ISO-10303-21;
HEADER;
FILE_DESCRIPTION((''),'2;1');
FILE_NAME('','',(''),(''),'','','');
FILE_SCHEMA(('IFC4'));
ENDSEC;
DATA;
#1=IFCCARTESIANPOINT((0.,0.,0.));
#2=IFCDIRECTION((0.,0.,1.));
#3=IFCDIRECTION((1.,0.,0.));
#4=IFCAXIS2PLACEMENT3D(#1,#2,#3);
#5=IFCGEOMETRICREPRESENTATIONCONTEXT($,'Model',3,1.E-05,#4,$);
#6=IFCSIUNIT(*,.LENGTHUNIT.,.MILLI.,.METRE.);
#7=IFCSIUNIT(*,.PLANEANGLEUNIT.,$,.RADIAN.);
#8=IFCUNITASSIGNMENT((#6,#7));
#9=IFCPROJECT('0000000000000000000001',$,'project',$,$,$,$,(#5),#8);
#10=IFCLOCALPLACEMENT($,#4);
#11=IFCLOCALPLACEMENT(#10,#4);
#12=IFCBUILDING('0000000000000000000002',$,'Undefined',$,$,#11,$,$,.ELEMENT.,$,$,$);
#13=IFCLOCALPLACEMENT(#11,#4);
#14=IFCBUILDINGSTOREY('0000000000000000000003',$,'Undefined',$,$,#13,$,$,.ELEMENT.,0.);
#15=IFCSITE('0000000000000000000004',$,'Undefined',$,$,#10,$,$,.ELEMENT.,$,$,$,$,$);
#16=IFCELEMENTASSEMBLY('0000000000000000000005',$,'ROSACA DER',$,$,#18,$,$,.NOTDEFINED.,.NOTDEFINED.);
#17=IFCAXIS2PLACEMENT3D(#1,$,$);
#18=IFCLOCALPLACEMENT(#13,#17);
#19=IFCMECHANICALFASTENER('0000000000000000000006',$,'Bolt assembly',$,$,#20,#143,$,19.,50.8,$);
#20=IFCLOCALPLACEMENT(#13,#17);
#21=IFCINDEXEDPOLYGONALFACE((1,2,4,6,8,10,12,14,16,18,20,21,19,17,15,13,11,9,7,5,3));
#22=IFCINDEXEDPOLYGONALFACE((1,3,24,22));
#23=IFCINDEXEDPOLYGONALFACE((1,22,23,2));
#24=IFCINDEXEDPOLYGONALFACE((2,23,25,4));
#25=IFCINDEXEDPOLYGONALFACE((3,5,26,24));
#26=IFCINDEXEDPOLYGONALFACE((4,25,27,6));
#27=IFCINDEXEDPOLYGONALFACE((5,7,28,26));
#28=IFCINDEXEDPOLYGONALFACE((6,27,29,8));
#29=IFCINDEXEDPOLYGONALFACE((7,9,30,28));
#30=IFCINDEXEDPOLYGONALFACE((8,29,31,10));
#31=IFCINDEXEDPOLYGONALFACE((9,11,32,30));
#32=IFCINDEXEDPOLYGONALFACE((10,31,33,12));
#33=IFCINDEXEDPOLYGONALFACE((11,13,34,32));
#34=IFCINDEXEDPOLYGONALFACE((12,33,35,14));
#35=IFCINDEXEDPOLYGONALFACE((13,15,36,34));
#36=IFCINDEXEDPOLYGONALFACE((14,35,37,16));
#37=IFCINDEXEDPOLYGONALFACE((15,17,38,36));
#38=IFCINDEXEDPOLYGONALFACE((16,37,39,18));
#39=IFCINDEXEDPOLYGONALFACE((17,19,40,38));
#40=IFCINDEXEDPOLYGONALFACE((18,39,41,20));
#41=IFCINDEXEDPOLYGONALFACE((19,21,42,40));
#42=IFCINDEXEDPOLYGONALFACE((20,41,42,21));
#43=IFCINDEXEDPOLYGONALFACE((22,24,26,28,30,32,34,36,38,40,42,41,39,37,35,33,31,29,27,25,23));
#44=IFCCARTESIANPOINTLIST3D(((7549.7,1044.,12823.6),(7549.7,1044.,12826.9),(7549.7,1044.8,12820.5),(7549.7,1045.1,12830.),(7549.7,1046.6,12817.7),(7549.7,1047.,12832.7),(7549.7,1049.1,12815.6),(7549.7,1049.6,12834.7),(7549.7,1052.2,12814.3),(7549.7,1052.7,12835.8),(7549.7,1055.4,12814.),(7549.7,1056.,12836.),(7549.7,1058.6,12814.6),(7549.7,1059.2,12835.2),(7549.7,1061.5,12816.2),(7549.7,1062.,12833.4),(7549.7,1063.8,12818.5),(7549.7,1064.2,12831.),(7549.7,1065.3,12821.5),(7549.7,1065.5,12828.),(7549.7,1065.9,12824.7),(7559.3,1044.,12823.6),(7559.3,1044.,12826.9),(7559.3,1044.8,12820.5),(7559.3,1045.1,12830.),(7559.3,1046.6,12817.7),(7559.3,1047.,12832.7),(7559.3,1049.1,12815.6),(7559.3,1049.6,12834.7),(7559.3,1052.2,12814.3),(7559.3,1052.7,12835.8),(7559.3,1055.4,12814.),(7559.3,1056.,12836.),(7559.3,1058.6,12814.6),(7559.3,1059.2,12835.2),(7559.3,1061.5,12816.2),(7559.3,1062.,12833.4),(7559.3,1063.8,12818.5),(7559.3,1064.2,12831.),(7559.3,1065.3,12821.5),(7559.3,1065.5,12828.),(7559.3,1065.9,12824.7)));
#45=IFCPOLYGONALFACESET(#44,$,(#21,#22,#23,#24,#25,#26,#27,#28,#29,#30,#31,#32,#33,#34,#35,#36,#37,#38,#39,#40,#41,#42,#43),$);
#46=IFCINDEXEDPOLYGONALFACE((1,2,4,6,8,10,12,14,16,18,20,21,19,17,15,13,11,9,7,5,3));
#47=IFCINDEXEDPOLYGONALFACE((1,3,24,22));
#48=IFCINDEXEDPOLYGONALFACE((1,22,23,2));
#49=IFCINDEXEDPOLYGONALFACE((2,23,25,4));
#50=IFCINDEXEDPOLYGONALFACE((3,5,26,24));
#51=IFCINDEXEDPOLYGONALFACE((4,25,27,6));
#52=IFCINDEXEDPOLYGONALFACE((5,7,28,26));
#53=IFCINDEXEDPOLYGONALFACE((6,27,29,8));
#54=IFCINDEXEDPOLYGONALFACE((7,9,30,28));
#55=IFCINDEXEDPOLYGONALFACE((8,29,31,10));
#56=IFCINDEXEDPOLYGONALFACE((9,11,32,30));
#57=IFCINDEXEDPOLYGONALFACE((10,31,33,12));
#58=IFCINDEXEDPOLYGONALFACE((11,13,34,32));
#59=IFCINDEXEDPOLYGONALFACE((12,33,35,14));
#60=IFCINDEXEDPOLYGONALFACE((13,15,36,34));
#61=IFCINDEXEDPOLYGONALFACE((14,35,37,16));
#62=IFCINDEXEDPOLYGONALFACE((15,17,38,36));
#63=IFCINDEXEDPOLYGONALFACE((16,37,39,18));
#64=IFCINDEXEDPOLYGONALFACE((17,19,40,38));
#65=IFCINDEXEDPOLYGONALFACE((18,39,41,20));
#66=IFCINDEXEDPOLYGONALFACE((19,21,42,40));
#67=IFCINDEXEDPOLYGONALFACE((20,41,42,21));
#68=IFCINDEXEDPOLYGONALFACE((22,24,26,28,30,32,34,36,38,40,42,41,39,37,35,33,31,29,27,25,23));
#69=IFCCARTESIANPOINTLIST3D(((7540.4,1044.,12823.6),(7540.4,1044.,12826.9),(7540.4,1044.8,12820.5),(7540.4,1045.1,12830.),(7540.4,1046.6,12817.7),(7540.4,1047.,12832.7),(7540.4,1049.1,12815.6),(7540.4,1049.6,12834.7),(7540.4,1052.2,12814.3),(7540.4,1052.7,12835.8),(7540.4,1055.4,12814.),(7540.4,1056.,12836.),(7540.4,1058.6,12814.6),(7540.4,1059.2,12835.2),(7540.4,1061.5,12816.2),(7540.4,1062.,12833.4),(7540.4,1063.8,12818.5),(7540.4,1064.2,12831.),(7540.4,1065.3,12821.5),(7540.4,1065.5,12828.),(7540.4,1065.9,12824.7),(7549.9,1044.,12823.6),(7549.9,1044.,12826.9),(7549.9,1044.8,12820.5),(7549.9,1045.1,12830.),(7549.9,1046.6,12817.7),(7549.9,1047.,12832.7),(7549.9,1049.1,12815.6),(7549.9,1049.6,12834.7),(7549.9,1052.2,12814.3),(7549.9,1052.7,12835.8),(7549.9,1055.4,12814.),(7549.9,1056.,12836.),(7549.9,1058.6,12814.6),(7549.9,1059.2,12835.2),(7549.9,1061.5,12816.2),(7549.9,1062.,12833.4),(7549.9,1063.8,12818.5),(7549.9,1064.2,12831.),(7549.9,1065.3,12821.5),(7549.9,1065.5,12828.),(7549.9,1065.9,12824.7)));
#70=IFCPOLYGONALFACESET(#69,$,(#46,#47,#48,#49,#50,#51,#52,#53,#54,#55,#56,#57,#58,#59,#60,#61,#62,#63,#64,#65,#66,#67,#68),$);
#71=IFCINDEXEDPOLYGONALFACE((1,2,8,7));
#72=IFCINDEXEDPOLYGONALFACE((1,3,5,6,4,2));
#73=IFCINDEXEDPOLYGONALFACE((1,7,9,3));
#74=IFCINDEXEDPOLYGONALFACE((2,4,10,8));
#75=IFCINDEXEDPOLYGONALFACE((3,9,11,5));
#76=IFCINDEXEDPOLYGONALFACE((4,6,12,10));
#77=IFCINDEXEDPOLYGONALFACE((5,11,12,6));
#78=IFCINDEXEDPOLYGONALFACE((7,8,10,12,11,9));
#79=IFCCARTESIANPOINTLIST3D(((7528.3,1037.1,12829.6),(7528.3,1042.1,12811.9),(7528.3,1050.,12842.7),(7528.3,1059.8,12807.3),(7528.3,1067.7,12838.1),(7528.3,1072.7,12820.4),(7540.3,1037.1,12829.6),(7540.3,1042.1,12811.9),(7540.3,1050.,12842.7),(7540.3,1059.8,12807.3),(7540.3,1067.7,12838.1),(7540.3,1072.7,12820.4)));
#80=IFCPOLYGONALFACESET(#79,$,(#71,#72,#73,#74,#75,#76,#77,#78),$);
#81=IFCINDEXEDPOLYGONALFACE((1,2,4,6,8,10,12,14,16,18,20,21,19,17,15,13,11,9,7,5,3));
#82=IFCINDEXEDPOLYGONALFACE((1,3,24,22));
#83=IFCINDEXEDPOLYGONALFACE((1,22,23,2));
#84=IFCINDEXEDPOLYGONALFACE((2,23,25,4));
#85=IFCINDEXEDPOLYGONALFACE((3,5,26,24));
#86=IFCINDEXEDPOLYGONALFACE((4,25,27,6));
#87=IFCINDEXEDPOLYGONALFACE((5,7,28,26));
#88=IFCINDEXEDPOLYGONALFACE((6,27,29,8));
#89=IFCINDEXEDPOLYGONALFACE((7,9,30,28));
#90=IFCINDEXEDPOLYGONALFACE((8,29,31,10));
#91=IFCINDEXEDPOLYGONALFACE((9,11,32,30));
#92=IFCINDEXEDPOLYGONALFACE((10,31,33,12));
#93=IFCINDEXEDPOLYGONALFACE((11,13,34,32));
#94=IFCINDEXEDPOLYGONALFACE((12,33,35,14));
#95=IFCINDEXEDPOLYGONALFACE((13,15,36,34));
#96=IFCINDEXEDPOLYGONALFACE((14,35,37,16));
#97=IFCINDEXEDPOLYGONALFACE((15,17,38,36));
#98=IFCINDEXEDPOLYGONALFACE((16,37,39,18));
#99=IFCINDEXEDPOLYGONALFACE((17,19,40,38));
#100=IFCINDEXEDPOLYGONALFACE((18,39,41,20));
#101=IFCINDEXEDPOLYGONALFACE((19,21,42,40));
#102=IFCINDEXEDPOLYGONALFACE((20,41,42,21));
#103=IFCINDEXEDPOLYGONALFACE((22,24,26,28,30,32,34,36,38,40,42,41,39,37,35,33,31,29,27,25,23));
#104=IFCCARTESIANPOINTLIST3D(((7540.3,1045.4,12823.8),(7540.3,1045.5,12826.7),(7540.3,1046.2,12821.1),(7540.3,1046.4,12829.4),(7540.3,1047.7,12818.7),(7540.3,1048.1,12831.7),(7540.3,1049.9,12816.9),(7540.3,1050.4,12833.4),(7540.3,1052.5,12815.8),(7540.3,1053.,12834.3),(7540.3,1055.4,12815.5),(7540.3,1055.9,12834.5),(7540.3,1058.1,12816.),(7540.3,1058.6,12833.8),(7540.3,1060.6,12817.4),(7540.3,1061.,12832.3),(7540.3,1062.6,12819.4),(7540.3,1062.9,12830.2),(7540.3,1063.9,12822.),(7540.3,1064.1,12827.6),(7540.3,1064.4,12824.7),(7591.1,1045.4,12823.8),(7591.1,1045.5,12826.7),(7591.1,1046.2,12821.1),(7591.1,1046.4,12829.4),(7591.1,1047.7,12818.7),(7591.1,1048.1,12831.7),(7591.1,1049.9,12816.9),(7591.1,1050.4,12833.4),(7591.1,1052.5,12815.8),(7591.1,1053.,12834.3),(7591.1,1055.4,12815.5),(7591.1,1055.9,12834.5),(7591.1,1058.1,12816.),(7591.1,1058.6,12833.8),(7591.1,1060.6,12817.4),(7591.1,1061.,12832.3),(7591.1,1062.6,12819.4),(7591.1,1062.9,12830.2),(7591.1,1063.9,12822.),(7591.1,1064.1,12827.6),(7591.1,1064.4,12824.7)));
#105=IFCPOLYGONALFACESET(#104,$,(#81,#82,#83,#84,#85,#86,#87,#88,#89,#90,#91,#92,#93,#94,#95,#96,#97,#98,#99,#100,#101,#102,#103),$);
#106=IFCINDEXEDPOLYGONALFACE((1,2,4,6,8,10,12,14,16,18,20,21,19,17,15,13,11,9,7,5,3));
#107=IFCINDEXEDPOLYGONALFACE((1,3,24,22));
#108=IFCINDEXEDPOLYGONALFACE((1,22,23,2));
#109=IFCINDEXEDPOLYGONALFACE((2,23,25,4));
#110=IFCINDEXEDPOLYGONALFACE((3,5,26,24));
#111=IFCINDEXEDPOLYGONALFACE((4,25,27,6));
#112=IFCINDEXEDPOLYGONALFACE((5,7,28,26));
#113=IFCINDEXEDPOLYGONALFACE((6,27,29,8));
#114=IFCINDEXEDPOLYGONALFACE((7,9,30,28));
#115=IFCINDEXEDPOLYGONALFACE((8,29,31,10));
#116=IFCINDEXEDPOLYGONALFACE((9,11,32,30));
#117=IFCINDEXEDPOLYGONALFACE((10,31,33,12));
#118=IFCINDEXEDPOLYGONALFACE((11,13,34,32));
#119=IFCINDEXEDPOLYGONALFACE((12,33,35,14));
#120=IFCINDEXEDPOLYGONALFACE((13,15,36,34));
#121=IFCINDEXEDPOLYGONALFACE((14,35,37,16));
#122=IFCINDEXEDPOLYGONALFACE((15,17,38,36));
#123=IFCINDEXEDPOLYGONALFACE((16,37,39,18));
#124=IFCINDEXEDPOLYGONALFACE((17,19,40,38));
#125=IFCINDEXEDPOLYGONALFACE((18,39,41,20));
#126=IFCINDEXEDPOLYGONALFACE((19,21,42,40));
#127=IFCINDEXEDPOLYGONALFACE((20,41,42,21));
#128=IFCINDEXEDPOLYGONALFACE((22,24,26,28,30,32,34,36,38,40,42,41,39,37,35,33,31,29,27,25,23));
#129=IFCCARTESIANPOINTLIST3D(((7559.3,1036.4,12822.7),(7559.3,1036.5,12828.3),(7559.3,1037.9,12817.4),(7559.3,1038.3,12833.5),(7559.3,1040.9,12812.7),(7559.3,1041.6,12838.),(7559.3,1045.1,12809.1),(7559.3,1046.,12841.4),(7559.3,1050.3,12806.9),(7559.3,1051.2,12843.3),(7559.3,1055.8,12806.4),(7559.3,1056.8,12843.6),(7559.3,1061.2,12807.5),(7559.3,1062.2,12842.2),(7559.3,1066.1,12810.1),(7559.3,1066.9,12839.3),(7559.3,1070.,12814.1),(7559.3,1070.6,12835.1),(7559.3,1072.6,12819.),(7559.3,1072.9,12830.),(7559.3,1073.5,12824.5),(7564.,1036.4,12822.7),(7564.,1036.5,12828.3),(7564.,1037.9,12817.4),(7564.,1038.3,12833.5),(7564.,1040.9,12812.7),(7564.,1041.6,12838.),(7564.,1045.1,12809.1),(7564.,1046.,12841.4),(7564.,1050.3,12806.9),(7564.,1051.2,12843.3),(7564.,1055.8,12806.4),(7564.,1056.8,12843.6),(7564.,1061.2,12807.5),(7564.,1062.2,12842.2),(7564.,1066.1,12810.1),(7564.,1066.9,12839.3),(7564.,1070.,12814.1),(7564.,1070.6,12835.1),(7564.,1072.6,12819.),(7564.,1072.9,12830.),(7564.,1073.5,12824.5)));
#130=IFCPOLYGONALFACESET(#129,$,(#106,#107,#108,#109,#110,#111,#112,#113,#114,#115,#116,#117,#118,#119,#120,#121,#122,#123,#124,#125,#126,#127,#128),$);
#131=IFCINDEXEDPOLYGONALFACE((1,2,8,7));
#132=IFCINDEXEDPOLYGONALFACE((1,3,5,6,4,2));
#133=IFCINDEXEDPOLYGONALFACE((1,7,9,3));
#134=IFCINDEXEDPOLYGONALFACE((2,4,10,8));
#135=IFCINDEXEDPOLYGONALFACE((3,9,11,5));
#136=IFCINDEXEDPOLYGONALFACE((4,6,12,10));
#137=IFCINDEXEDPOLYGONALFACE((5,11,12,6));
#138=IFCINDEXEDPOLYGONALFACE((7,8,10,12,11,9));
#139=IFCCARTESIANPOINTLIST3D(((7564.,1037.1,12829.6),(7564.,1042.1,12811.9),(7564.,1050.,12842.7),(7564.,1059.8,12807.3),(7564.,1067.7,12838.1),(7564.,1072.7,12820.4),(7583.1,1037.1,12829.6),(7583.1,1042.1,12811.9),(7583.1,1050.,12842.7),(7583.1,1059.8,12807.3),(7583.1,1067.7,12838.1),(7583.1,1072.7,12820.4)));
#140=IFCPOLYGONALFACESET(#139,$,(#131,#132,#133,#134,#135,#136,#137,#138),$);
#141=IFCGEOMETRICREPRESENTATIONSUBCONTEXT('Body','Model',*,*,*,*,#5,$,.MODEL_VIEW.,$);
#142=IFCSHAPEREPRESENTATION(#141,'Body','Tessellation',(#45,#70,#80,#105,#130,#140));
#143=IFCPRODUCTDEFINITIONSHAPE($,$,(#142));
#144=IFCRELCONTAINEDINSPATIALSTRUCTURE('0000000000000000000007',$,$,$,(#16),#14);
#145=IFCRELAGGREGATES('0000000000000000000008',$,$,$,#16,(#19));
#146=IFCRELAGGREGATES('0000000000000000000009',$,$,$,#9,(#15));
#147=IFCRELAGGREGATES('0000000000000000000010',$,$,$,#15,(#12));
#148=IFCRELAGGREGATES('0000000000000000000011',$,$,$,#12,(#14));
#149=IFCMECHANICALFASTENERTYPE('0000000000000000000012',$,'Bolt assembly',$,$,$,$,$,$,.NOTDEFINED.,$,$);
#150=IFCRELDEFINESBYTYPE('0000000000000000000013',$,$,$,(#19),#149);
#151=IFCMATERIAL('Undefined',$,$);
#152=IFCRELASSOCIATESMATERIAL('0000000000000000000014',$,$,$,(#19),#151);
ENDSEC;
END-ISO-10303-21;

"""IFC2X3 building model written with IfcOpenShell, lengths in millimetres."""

from ifc_helpers import new_model, si_unit, frame, origin_with_axes, origin_2d_with_axis, place, context, subcontext, project, spatial, polyline, circle, outline, extrude, source, transform, mapped, material, type_object, element, aggregate, save


model = new_model("IFC2X3")

# Units and contexts
model_context = context("Model", 3, precision=1e-05, world=origin_with_axes())
body_context = subcontext(model_context, "Body", "Model", "MODEL_VIEW")
ifc_project = project(units=[si_unit("LENGTHUNIT", "METRE", prefix="MILLI"), si_unit("PLANEANGLEUNIT", "RADIAN")], contexts=[model_context])

# Site, building, storey
site_placement = place(None, origin_with_axes())
site = spatial("IfcSite", under=ifc_project, at=site_placement, Name="Undefined", CompositionType="ELEMENT")
building_placement = place(site_placement, origin_with_axes())
building = spatial("IfcBuilding", under=site, at=building_placement, Name="Undefined", CompositionType="ELEMENT")
storey_placement = place(building_placement, origin_with_axes())
storey = spatial("IfcBuildingStorey", under=building, at=storey_placement, Name="Undefined", CompositionType="ELEMENT", Elevation=0.0)

# Element assembly
assembly_1_placement = place(storey_placement, origin_with_axes())
assembly_1 = element("IfcElementAssembly", 1, at=assembly_1_placement, inside=storey, Name="ROSACA DER", AssemblyPlace="NOTDEFINED", PredefinedType="NOTDEFINED")

# Shared definitions
ifc_material_1 = material(Name="Undefined")
mechanical_fastener_type = type_object("IfcMechanicalFastenerType", Name="Bolt assembly")

# Mechanical fastener
shared_shape_1 = source(origin_with_axes(), body_context, "Body", "SweptSolid", [
    extrude(circle(Radius=11.0, at=origin_2d_with_axis()), frame((0.0, 4.6, 0.0), z_axis=(0.0, 1.0, 0.0), x_axis=(1.0, 0.0, 0.0)), (0.0, 0.0, 1.0), 9.6),
    extrude(circle(Radius=11.0, at=origin_2d_with_axis()), frame((0.0, -4.6, 0.0), z_axis=(0.0, 1.0, 0.0), x_axis=(1.0, 0.0, 0.0)), (0.0, 0.0, 1.0), 9.5),
    extrude(outline(polyline([(15.9, -9.2), (15.9, 9.2), (0.0, 18.3), (-15.9, 9.2), (-15.9, -9.2), (0.0, -18.3), (15.9, -9.2)])), frame((0.0, -16.7, 0.0), z_axis=(0.0, 1.0, 0.0), x_axis=(1.0, 0.0, 0.0)), (0.0, 0.0, 1.0), 11.9),
    extrude(circle(Radius=9.5, at=origin_2d_with_axis()), frame((0.0, -4.7, 0.0), z_axis=(0.0, 1.0, 0.0), x_axis=(1.0, 0.0, 0.0)), (0.0, 0.0, 1.0), 50.8),
    extrude(circle(Radius=18.7, at=origin_2d_with_axis()), frame((0.0, 14.2, 0.0), z_axis=(0.0, 1.0, 0.0), x_axis=(1.0, 0.0, 0.0)), (0.0, 0.0, 1.0), 4.8),
    extrude(outline(polyline([(15.9, -9.2), (15.9, 9.2), (0.0, 18.3), (-15.9, 9.2), (-15.9, -9.2), (0.0, -18.3), (15.9, -9.2)])), frame((0.0, 19.0, 0.0), z_axis=(0.0, 1.0, 0.0), x_axis=(1.0, 0.0, 0.0)), (0.0, 0.0, 1.0), 19.1),
])
mechanical_fastener_1_placement = place(assembly_1_placement, frame((7545.0, 1054.9, 12825.0), z_axis=(0.0, 0.269162, -0.963095), x_axis=(0.0, 0.963095, 0.269162)))
mechanical_fastener_1 = element("IfcMechanicalFastener", 2, at=mechanical_fastener_1_placement, type_object=mechanical_fastener_type, material=ifc_material_1, Name="Bolt assembly", NominalDiameter=19.0, NominalLength=50.8, context=body_context, shape_type="MappedRepresentation", body=[
    mapped(shared_shape_1, transform((0.0, 0.0, 0.0))),
])
aggregate(assembly_1, [mechanical_fastener_1])

save(model, "model.ifc")
